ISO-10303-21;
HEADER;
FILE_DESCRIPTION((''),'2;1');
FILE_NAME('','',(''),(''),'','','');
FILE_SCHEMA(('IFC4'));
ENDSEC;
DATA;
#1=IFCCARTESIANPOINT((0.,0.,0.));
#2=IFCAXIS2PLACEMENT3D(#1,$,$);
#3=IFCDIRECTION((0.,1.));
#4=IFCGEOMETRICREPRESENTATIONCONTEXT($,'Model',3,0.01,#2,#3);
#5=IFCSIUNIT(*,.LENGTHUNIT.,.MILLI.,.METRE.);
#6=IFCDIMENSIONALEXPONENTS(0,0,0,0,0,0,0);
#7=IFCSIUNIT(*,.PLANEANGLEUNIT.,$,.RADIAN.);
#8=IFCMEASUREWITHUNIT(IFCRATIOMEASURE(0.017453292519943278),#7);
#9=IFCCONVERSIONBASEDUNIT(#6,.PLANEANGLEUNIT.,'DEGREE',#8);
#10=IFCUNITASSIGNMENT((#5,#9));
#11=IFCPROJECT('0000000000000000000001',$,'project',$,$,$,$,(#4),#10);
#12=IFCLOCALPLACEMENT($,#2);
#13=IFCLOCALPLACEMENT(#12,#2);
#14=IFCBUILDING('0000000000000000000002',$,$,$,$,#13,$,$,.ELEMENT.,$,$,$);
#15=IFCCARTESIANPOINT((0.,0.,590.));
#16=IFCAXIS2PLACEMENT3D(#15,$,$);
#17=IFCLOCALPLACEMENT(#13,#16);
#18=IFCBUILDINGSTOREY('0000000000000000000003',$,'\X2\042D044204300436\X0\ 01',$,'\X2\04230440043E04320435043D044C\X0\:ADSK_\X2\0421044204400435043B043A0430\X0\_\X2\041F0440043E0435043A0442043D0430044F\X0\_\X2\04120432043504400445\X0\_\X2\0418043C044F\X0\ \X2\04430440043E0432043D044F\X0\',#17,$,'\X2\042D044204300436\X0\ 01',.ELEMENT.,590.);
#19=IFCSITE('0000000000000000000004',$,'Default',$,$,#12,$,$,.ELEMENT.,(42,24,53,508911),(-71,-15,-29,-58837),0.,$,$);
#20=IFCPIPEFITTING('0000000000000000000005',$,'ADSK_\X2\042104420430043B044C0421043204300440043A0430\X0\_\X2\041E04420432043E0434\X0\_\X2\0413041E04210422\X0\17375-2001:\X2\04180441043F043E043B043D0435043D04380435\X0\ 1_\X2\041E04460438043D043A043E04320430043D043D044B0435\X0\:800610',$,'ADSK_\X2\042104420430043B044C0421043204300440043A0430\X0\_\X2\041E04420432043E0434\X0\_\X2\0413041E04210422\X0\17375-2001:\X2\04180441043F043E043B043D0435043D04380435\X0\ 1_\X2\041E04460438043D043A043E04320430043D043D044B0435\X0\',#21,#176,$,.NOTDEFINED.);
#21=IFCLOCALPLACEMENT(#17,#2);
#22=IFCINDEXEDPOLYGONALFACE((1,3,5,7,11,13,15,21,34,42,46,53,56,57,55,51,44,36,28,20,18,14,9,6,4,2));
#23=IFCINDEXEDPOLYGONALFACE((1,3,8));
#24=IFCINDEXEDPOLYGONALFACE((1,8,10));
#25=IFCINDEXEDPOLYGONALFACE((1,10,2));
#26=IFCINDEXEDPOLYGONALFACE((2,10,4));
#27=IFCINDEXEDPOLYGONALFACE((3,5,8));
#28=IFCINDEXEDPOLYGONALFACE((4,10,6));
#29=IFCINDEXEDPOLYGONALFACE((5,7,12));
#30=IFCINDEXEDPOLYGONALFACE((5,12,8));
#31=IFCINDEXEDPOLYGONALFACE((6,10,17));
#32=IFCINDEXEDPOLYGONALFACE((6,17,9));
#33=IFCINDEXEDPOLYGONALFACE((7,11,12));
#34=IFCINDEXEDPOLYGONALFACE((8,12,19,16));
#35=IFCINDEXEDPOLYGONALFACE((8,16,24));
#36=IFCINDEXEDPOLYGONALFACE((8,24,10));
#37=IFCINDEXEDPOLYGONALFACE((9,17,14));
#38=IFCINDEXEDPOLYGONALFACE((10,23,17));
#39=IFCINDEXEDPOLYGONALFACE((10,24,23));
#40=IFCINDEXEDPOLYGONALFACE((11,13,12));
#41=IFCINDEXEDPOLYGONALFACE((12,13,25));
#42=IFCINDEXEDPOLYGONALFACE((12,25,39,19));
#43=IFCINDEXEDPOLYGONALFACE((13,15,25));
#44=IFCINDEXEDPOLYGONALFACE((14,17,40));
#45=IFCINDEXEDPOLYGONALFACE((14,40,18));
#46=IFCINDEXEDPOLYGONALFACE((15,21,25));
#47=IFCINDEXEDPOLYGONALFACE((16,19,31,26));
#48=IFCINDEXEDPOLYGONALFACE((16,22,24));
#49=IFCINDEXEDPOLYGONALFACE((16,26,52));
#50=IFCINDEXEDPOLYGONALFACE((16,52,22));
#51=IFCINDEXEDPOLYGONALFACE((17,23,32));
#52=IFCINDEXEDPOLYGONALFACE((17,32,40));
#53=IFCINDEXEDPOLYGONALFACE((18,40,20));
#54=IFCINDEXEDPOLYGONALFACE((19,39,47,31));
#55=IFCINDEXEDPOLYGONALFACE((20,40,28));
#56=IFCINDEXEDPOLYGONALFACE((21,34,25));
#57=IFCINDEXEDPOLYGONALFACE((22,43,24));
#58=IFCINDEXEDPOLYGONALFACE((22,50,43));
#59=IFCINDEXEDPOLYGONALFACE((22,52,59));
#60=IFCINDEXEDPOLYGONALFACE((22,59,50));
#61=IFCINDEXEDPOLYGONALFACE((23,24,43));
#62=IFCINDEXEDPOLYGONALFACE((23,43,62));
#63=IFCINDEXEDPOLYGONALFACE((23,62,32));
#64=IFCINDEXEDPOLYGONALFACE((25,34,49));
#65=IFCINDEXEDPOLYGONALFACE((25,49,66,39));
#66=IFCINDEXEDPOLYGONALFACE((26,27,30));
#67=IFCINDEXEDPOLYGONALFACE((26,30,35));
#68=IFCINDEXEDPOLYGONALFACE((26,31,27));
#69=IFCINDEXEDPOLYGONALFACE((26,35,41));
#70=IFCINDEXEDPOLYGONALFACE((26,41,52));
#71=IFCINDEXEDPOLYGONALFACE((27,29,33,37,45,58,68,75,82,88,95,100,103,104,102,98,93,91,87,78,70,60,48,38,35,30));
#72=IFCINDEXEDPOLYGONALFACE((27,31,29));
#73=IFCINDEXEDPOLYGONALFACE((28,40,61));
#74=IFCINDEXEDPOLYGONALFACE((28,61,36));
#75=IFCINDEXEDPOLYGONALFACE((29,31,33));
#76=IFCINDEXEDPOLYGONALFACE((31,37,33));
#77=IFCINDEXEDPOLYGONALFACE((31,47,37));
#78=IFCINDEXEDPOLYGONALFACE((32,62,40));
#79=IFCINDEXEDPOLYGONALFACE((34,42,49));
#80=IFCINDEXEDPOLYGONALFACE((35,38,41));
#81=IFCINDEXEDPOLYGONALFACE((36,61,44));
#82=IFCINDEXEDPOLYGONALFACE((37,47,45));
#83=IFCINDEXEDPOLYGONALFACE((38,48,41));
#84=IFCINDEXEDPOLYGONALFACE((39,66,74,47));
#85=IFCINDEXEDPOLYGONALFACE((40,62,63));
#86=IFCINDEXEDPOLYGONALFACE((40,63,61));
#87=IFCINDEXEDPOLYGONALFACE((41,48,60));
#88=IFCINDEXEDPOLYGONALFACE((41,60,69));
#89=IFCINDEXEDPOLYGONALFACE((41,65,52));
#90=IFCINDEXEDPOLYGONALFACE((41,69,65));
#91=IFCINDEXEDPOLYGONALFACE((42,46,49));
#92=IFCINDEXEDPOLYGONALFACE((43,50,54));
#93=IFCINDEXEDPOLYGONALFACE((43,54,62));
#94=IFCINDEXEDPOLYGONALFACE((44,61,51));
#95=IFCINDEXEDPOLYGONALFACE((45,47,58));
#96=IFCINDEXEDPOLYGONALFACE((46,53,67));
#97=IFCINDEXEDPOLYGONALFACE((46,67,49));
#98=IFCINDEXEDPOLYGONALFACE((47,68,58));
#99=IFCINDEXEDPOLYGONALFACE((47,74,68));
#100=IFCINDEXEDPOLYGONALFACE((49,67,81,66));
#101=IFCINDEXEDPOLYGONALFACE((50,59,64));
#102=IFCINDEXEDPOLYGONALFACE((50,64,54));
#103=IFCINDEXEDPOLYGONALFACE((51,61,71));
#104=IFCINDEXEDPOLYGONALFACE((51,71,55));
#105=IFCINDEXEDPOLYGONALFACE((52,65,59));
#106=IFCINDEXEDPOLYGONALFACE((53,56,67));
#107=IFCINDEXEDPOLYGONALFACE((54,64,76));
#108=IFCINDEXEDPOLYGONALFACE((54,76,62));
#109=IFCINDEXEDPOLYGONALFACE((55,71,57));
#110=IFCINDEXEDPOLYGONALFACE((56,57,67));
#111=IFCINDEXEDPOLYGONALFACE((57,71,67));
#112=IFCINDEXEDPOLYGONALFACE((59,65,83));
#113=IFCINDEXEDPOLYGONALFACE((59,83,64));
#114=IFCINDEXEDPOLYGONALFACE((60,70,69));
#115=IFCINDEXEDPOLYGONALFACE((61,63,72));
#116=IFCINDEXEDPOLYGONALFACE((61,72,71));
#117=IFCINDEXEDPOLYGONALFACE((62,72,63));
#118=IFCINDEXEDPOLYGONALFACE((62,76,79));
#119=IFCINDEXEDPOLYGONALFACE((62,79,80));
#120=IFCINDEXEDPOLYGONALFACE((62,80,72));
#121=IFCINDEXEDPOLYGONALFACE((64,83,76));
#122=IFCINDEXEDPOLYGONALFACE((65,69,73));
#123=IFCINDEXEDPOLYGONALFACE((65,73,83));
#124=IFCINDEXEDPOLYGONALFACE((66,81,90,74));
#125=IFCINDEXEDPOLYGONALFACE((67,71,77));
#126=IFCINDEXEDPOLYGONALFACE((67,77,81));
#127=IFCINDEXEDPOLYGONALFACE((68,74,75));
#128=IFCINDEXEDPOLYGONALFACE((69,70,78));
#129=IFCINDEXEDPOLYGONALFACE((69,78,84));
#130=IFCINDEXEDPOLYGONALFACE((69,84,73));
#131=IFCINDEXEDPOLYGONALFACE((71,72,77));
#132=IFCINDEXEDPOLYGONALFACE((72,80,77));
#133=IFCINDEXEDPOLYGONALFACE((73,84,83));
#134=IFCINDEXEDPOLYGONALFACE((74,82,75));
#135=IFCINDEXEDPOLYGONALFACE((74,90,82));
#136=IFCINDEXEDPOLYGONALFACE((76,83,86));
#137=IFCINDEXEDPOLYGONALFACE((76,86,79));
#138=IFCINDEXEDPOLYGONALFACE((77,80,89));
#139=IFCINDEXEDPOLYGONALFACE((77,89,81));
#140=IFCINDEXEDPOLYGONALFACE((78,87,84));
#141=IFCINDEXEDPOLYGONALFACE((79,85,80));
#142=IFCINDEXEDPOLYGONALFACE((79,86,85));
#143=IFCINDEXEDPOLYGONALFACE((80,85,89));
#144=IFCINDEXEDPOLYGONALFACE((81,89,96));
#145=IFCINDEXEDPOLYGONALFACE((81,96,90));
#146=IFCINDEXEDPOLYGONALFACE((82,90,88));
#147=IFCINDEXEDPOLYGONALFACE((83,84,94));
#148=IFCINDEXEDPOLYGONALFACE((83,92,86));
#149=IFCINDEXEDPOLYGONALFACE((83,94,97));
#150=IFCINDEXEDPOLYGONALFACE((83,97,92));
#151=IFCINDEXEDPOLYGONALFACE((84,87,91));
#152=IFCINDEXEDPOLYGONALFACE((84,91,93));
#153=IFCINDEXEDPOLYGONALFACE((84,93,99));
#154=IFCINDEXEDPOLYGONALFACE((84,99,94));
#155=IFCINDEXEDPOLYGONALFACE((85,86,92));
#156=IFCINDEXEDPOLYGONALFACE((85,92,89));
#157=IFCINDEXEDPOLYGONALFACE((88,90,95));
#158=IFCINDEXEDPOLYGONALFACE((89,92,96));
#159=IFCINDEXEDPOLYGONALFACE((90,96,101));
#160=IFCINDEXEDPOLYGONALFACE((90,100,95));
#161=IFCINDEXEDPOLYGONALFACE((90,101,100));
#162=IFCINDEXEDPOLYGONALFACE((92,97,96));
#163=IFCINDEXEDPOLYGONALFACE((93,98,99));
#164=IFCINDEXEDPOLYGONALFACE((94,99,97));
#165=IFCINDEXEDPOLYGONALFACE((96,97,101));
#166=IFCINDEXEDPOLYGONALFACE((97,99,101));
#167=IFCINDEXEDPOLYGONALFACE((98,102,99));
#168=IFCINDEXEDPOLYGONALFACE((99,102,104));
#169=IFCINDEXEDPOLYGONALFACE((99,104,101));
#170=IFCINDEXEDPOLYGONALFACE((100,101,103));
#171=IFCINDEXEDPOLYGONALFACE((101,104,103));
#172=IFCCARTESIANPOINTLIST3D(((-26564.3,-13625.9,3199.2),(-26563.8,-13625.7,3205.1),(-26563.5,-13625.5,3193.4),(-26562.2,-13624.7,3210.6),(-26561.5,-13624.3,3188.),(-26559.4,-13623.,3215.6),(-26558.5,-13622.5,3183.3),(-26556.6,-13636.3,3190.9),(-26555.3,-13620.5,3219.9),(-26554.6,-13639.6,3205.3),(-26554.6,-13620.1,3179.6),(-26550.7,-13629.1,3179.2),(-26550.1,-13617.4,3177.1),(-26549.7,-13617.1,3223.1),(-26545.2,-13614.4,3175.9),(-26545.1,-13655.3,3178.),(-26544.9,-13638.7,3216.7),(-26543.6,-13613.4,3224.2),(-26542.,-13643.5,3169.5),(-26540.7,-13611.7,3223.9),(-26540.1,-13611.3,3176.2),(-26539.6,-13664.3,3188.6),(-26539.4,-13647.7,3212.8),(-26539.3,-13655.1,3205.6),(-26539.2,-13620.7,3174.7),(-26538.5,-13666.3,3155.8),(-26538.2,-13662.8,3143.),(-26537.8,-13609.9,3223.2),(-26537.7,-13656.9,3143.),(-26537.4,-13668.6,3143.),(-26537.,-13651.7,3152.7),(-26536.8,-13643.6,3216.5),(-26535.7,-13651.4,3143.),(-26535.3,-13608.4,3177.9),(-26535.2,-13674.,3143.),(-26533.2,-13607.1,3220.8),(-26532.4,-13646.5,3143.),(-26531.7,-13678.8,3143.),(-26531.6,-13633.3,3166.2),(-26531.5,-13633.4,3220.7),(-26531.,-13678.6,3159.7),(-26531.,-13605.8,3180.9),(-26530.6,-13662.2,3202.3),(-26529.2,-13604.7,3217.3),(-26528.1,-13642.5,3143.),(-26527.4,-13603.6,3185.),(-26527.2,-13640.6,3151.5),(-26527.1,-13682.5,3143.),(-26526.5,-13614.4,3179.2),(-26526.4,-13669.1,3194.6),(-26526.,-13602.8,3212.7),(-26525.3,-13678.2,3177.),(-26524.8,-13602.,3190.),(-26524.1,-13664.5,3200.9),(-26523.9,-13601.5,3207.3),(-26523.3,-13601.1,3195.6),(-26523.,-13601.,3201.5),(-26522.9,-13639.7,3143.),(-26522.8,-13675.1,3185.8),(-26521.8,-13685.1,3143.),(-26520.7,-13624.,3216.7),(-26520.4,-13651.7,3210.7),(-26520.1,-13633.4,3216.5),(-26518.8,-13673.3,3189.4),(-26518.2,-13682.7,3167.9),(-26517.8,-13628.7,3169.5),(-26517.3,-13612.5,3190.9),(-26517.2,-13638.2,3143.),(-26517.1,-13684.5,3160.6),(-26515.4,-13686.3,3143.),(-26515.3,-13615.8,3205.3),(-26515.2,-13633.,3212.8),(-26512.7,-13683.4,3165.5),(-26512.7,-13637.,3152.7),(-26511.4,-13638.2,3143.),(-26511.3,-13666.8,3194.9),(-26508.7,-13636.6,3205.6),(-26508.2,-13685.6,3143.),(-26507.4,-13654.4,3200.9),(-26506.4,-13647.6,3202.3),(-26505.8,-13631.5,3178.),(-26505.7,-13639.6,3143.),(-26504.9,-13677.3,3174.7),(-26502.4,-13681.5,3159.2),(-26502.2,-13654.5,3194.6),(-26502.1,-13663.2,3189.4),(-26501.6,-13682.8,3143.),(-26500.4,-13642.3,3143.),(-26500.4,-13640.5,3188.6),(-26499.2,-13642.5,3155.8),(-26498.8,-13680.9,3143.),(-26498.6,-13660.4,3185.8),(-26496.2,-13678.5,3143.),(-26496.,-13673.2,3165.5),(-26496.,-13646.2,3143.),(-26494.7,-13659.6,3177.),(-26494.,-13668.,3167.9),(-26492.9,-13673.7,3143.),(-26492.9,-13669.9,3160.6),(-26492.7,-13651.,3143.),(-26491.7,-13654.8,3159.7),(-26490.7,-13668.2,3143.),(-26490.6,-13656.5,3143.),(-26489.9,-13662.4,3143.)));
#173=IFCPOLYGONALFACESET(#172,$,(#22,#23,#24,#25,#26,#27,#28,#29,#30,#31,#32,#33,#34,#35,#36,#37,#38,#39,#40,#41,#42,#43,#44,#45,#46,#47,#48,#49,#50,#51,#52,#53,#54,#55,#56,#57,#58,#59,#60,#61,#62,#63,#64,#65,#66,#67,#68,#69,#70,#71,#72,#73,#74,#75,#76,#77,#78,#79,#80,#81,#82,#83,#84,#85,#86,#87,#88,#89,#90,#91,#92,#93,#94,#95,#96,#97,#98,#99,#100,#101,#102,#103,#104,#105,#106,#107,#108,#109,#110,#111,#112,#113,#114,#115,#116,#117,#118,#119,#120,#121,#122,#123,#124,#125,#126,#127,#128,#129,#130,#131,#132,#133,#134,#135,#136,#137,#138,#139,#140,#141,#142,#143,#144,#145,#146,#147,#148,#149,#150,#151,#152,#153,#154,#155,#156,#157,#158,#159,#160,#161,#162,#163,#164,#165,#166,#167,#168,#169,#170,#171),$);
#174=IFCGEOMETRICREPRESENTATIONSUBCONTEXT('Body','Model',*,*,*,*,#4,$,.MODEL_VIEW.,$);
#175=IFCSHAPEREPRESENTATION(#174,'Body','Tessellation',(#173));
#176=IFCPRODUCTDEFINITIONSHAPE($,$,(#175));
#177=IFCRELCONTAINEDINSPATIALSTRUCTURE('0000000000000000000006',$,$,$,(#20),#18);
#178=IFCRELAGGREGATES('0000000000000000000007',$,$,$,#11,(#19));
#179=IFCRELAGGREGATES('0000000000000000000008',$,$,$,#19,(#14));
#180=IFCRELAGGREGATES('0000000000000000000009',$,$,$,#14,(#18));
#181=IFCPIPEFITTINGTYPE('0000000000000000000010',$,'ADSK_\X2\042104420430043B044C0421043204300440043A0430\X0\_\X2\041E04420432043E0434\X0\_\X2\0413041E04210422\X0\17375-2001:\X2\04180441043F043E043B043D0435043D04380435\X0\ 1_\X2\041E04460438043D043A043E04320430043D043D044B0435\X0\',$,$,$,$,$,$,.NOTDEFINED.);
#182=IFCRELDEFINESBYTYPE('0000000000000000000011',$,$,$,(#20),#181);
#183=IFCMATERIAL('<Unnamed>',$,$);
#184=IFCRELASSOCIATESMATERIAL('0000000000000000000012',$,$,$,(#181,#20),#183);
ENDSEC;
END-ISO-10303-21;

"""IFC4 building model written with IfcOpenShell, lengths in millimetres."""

from ifc_helpers import new_model, entity, si_unit, converted_unit, direction, frame, origin, place, context, subcontext, project, spatial, source, transform, mapped, material, type_object, type_shapes, element, save


model = new_model("IFC4")

# Units and contexts
model_context = context("Model", 3, precision=0.01, world=origin(), true_north=direction((0.0, 1.0)))
body_context = subcontext(model_context, "Body", "Model", "MODEL_VIEW")
ifc_project = project(units=[si_unit("LENGTHUNIT", "METRE", prefix="MILLI"), converted_unit("PLANEANGLEUNIT", "DEGREE", entity("IfcRatioMeasure", 0.017453292519943278), si_unit("PLANEANGLEUNIT", "RADIAN"), dimensions=[0, 0, 0, 0, 0, 0, 0])], contexts=[model_context])

# Site, building, storey
site_placement = place(None, origin())
site = spatial("IfcSite", under=ifc_project, at=site_placement, Name="Default", CompositionType="ELEMENT", RefLatitude=(42, 24, 53, 508911), RefLongitude=(-71, -15, -29, -58837), RefElevation=0.0)
building_placement = place(site_placement, origin())
building = spatial("IfcBuilding", under=site, at=building_placement, CompositionType="ELEMENT")
storey_placement = place(building_placement, frame((0.0, 0.0, 590.0)))
storey = spatial("IfcBuildingStorey", under=building, at=storey_placement, Name="Этаж 01", ObjectType="Уровень:ADSK_Стрелка_Проектная_Вверх_Имя уровня", LongName="Этаж 01", CompositionType="ELEMENT", Elevation=590.0)

# Shared definitions
ifc_material_1 = material(Name="<Unnamed>")

# Pipe fitting
pipe_fitting_type = type_object("IfcPipeFittingType", Name="ADSK_СтальСварка_Отвод_ГОСТ17375-2001:Исполнение 1_Оцинкованные", PredefinedType="NOTDEFINED", material=ifc_material_1)
ifc_direction = entity("IfcDirection", [0.0, 0.0, 1.0])
trimmed_curve = entity("IfcTrimmedCurve", entity("IfcCircle", entity("IfcAxis2Placement2D", entity("IfcCartesianPoint", [-57.0, 0.0]), entity("IfcDirection", [0.0, 1.0])), 57.0), [entity("IfcParameterValue", 270.0)], [entity("IfcParameterValue", 0.0)], True, "PARAMETER")
shared_shape_1 = source(origin(), body_context, "Body", "AdvancedSweptSolid", [
    entity("IfcSurfaceCurveSweptAreaSolid", entity("IfcCircleProfileDef", "AREA", None, entity("IfcAxis2Placement2D", entity("IfcCartesianPoint", [0.0, 0.0]), entity("IfcDirection", [1.0, 0.0])), 24.1), entity("IfcAxis2Placement3D", entity("IfcCartesianPoint", [-57.0, 0.0, 0.0]), ifc_direction, entity("IfcDirection", [0.0, -1.0, 0.0])), trimmed_curve, 0.0, 90.0, entity("IfcSurfaceOfLinearExtrusion", entity("IfcArbitraryOpenProfileDef", "CURVE", None, trimmed_curve), entity("IfcAxis2Placement3D", entity("IfcCartesianPoint", [0.0, 0.0, -304.8])), ifc_direction, 1.0)),
])
type_shapes(pipe_fitting_type, [shared_shape_1])
for number, where, z_axis, x_axis, name in (
    (1, (-26514.1, -13662.2, 3200.0), (0.855267, 0.518188, 0.0), (0.518188, -0.855267, 0.0), "ADSK_СтальСварка_Отвод_ГОСТ17375-2001:Исполнение 1_Оцинкованные:800610"),
):
    element("IfcPipeFitting", number, at=place(storey_placement, frame(where, z_axis=z_axis, x_axis=x_axis)), inside=storey, type_object=pipe_fitting_type, material=ifc_material_1, Name=name, ObjectType="ADSK_СтальСварка_Отвод_ГОСТ17375-2001:Исполнение 1_Оцинкованные", PredefinedType="NOTDEFINED", context=body_context, shape_type="MappedRepresentation", body=[
        mapped(shared_shape_1, transform((0.0, 0.0, 0.0), scale=1.0)),
    ])

save(model, "model.ifc")
